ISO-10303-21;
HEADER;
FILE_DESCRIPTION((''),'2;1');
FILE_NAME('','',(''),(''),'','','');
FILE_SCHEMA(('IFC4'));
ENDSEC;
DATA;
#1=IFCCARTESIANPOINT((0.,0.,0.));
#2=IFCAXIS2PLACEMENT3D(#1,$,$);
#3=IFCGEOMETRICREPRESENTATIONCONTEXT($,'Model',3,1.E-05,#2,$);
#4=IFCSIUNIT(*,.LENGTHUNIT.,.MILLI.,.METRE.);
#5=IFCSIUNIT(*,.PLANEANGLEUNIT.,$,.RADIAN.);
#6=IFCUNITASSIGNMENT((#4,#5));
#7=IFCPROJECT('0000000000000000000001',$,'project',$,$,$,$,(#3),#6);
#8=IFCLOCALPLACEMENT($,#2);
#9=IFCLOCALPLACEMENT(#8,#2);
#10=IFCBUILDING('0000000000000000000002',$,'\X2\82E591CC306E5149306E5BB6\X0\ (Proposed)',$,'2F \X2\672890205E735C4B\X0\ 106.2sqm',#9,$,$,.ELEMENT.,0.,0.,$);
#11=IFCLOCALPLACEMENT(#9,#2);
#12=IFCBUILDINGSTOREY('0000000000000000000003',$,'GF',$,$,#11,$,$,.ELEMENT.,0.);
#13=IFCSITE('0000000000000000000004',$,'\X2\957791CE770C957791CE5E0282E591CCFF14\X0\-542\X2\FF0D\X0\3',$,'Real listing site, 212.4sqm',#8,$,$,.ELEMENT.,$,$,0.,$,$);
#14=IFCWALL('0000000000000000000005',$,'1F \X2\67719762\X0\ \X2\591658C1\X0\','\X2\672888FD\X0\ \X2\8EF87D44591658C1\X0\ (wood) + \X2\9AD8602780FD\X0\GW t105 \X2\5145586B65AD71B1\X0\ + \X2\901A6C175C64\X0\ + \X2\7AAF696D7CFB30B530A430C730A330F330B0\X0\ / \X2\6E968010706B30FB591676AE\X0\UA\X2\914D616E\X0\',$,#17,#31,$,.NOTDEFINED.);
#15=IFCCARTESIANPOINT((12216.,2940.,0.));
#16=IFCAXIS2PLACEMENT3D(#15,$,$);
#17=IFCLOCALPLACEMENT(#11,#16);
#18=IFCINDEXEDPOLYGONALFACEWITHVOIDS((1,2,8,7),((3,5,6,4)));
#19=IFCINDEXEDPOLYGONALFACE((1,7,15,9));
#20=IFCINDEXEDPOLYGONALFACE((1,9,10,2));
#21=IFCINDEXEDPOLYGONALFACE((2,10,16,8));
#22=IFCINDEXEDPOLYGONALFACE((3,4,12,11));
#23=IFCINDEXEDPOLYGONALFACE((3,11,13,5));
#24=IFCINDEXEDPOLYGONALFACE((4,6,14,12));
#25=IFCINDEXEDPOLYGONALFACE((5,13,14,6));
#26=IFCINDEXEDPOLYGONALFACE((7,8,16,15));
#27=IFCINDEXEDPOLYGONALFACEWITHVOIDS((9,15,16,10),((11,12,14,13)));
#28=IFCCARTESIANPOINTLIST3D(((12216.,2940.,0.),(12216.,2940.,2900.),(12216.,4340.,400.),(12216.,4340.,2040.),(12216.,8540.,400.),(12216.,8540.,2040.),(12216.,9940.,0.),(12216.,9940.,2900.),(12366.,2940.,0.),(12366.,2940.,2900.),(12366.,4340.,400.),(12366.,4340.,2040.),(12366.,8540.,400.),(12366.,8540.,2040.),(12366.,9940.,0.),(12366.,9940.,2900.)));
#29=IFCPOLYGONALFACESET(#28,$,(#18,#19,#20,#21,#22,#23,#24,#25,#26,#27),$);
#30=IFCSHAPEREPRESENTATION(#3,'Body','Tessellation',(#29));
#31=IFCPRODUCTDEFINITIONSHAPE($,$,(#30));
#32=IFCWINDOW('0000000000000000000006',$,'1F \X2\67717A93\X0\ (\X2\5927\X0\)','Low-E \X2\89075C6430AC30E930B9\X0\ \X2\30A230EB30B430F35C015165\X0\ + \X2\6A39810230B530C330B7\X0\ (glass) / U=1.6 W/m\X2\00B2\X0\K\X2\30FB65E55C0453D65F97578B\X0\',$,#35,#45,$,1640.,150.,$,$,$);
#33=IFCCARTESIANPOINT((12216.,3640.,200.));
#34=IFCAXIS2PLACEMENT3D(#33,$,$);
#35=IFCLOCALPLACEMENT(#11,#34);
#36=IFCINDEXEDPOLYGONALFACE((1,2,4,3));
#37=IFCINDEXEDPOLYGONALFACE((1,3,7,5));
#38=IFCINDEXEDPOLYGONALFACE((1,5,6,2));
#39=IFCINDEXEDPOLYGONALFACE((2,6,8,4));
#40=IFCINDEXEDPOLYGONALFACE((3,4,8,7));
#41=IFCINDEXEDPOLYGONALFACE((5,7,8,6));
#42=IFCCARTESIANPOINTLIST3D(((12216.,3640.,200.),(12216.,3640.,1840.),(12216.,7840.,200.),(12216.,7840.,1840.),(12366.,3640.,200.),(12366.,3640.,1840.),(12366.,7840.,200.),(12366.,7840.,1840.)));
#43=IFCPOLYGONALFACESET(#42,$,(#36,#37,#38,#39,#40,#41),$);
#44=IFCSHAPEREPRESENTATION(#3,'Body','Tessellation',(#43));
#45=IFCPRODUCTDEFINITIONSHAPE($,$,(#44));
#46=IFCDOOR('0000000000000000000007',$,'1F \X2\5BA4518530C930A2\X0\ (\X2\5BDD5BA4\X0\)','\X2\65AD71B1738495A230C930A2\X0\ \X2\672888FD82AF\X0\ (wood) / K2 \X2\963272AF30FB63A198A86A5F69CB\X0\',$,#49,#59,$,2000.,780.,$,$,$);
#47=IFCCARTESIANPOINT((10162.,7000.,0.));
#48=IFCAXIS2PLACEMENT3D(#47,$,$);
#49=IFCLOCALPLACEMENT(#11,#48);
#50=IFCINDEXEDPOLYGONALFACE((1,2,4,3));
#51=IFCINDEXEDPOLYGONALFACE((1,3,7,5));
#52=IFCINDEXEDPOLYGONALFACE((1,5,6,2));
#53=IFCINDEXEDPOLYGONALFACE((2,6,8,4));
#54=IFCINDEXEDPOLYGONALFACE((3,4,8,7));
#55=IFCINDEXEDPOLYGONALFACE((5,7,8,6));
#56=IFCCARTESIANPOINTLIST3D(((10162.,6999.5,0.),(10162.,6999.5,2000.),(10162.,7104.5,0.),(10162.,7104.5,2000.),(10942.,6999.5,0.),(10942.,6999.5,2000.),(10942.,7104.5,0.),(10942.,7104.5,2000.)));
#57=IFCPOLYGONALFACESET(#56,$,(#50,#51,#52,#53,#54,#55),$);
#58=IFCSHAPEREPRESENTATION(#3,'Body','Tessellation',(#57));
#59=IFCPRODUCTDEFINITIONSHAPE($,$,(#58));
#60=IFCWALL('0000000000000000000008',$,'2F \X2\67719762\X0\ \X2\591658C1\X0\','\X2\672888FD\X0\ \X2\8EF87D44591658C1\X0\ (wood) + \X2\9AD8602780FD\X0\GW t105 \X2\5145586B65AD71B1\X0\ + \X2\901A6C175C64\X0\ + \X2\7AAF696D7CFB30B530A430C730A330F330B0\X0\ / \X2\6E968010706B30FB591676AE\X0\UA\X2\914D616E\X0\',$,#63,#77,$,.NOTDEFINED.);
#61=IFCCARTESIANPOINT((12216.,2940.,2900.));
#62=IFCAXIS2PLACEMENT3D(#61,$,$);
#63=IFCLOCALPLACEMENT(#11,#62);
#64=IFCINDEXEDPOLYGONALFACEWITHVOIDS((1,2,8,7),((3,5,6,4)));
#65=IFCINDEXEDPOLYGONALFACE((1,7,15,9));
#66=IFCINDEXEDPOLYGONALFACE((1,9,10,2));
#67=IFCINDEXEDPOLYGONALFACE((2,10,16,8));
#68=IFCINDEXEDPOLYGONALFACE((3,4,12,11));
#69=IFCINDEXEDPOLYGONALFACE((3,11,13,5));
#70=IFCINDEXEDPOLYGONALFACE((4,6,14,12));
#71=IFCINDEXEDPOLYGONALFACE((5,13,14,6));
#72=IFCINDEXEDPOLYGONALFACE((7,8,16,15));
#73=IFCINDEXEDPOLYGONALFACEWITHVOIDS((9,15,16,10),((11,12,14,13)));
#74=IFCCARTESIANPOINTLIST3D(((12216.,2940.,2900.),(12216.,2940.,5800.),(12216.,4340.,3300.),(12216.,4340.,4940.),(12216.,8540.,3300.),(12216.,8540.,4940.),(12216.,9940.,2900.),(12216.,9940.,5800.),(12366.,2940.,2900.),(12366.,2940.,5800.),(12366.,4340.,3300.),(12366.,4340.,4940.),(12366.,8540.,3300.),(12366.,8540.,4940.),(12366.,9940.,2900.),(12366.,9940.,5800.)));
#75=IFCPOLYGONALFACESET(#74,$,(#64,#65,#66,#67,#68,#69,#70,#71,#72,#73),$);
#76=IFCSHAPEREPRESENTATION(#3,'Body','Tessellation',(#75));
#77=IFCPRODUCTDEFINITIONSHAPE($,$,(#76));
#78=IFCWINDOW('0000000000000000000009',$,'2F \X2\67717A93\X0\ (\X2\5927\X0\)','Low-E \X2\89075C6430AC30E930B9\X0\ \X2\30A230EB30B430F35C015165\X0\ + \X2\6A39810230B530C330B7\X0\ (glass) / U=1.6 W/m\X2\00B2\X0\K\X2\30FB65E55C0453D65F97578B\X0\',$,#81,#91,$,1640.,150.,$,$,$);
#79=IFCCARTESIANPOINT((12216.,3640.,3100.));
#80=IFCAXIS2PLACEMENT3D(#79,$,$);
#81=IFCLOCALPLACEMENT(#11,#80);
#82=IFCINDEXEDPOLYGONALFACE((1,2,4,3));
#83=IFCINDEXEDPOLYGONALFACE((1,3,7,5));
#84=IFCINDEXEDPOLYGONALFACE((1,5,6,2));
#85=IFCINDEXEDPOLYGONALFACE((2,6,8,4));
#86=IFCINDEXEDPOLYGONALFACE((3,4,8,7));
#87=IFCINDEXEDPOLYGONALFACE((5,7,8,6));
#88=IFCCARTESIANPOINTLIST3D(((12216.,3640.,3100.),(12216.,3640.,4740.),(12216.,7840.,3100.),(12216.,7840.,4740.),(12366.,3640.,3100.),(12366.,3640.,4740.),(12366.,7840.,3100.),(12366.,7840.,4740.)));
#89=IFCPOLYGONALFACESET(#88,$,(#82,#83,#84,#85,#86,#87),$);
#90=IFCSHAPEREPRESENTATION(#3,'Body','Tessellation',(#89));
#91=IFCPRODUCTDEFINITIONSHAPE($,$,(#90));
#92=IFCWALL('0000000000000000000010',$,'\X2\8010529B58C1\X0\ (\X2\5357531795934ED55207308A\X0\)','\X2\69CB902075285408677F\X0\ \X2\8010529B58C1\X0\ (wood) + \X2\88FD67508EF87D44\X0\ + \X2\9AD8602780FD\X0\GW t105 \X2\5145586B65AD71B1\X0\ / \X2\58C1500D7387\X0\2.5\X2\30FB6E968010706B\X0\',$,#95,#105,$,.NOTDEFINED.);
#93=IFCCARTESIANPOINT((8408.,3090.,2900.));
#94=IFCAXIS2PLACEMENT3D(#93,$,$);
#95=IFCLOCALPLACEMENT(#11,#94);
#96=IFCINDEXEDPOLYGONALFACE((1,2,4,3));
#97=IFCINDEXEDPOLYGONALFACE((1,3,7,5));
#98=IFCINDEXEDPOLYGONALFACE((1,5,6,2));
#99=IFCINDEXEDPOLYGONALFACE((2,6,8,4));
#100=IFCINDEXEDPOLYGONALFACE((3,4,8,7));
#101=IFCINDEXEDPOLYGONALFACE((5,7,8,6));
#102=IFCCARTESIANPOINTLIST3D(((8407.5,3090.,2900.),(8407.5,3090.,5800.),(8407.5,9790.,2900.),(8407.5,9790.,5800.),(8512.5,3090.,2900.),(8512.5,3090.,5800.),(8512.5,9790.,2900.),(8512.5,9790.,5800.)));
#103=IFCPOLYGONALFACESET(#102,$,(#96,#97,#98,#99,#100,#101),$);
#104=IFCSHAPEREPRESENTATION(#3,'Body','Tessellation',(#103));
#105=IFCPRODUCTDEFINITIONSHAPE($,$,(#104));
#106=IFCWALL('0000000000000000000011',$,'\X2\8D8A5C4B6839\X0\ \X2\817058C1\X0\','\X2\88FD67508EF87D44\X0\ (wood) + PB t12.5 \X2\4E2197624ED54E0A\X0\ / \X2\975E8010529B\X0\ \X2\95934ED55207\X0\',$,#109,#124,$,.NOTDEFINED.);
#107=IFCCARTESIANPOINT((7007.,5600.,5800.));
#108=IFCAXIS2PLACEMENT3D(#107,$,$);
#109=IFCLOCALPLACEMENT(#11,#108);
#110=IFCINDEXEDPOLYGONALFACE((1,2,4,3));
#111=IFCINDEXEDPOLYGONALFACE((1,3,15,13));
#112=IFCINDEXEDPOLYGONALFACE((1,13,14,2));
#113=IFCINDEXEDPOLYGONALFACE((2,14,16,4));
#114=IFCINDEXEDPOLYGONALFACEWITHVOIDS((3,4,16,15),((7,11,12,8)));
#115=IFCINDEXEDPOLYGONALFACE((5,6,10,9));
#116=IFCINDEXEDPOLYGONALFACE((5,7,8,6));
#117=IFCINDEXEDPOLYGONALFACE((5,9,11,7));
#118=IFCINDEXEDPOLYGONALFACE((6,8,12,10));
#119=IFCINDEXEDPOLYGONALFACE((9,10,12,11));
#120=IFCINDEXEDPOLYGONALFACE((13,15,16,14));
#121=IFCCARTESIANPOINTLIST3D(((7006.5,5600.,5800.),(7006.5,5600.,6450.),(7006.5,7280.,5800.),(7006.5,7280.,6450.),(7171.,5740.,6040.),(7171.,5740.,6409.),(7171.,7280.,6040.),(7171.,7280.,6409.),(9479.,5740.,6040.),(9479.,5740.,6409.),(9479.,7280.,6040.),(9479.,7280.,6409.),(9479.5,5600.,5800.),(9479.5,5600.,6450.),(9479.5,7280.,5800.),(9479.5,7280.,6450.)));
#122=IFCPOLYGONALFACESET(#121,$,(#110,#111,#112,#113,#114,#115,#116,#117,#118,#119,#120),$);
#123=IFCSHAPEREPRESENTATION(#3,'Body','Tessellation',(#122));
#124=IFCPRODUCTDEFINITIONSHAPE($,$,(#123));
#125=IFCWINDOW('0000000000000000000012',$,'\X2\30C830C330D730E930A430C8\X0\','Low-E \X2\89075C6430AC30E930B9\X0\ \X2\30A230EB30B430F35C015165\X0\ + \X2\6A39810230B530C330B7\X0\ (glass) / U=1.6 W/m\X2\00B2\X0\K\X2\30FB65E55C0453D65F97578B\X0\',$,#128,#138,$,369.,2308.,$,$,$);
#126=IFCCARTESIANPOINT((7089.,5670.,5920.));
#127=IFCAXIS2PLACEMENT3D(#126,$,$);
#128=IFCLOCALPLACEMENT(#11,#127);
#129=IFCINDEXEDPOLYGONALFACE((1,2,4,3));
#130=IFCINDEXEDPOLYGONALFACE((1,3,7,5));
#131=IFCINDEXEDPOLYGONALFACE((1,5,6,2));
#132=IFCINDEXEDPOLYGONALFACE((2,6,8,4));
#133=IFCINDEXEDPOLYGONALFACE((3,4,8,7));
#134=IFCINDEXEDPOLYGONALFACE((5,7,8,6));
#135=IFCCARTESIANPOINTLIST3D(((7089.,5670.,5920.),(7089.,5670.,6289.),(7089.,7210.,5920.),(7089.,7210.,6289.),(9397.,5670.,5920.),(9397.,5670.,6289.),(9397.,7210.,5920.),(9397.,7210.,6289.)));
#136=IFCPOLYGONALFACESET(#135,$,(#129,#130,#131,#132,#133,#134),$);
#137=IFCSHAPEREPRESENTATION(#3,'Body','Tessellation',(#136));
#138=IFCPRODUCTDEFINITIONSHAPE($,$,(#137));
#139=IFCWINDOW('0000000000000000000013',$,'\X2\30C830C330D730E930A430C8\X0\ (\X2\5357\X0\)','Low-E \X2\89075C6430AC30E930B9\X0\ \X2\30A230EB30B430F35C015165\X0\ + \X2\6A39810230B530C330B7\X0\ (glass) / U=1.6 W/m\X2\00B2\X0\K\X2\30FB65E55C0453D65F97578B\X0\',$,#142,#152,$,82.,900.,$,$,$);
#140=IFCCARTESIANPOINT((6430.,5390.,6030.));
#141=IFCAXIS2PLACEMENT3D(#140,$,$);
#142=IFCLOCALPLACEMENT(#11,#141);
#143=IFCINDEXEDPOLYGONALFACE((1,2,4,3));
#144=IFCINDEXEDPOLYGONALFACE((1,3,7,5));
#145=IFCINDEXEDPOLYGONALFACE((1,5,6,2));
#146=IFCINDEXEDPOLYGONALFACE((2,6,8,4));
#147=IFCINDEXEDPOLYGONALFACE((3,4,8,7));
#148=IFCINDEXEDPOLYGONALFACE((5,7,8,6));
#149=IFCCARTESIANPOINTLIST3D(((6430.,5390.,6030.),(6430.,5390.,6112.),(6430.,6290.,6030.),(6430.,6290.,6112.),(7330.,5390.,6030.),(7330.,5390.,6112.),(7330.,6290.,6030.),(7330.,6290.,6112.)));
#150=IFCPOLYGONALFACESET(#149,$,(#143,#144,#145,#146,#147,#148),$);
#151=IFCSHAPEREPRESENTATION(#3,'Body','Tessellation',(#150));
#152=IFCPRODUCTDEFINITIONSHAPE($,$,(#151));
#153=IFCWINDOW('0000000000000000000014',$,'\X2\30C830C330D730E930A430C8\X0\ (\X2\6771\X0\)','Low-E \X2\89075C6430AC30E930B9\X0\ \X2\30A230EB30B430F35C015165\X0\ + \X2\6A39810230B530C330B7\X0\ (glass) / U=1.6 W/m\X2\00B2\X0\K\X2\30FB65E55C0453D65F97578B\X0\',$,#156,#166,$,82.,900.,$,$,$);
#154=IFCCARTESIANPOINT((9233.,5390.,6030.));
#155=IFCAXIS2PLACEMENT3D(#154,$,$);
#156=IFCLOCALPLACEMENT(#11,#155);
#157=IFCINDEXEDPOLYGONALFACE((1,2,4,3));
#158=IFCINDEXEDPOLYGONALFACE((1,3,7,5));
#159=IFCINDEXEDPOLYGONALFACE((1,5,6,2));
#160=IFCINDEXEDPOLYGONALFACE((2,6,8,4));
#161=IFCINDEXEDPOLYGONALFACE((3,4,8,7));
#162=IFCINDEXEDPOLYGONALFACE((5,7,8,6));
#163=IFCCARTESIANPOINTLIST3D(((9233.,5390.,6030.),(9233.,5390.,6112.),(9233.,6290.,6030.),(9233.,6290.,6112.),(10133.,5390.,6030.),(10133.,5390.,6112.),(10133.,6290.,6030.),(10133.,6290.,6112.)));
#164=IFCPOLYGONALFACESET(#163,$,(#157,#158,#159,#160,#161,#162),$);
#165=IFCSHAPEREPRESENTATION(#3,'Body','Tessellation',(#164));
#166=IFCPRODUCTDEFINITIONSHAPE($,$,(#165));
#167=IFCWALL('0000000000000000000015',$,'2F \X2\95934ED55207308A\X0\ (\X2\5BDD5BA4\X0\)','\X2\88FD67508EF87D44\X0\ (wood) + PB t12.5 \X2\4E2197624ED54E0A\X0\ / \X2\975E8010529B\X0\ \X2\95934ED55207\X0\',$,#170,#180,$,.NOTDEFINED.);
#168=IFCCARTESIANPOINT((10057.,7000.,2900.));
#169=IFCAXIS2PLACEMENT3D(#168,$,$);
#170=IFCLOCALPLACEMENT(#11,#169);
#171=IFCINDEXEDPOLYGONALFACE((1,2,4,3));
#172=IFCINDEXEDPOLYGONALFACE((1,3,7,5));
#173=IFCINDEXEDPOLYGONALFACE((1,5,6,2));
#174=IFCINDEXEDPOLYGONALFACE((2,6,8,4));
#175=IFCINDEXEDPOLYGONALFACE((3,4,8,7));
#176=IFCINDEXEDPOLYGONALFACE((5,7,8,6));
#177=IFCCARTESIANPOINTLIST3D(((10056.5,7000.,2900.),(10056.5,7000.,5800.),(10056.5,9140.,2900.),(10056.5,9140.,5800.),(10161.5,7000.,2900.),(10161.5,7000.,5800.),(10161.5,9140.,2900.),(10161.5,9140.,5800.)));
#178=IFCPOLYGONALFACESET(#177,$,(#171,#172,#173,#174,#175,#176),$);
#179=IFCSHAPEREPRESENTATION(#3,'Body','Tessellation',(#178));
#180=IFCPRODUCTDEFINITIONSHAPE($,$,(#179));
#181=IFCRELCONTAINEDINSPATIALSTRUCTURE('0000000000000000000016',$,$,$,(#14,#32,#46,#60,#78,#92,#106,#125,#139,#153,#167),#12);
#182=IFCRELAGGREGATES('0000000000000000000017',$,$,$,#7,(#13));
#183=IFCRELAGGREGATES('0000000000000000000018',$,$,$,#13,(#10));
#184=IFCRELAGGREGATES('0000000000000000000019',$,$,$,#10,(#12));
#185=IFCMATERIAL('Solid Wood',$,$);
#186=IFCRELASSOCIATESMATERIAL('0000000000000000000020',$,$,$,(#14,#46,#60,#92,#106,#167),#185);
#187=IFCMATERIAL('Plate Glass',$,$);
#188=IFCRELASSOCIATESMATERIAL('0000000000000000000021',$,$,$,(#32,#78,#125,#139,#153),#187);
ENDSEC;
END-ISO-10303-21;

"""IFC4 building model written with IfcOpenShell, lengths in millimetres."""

from ifc_helpers import new_model, si_unit, frame, frame_2d, origin, place, context, project, spatial, rectangle, extrude, material, element, fill, save


model = new_model("IFC4")

# Units and contexts
model_context = context("Model", 3, precision=1e-05, world=origin())
ifc_project = project(units=[si_unit("LENGTHUNIT", "METRE", prefix="MILLI"), si_unit("PLANEANGLEUNIT", "RADIAN")], contexts=[model_context])

# Site, building, storey
site_placement = place(None, origin())
site = spatial("IfcSite", under=ifc_project, at=site_placement, Name="長野県長野市若里４-542－3", ObjectType="Real listing site, 212.4sqm", CompositionType="ELEMENT", RefElevation=0.0)
building_placement = place(site_placement, origin())
building = spatial("IfcBuilding", under=site, at=building_placement, Name="若里の光の家 (Proposed)", ObjectType="2F 木造平屋 106.2sqm", CompositionType="ELEMENT", ElevationOfRefHeight=0.0, ElevationOfTerrain=0.0)
storey_placement = place(building_placement, origin())
storey = spatial("IfcBuildingStorey", under=building, at=storey_placement, Name="GF", CompositionType="ELEMENT", Elevation=0.0)

# Wall, opening, window
ifc_material_1 = material(Name="Solid Wood")
wall_1_placement = place(storey_placement, frame((12216.0, 2940.0, 0.0)))
wall_1 = element("IfcWall", 1, at=wall_1_placement, inside=storey, material=ifc_material_1, Name="1F 東面 外壁", Description="木製 軸組外壁 (wood) + 高性能GW t105 充填断熱 + 通気層 + 窯業系サイディング / 準耐火・外皮UA配慮", PredefinedType="NOTDEFINED", context=model_context, shape_type="SweptSolid", body=[
    extrude(rectangle(XDim=150.0, YDim=7000.0, at=frame_2d((75.0, 3500.0))), frame((12216.0, 2940.0, 0.0)), (0.0, 0.0, 1.0), 2900.0),
])
opening_1_placement = place(storey_placement, frame((12216.0, 3640.0, 200.0)))
opening_1 = element("IfcOpeningElement", 2, at=opening_1_placement, cuts=wall_1, PredefinedType="NOTDEFINED", context=model_context, shape_type="SweptSolid", body=[
    extrude(rectangle(XDim=150.0, YDim=4200.0, at=frame_2d((75.0, 2100.0))), frame((12216.0, 3640.0, 200.0)), (0.0, 0.0, 1.0), 1640.0),
])
ifc_material_2 = material(Name="Plate Glass")
window_1_placement = place(storey_placement, frame((12216.0, 3640.0, 200.0)))
window_1 = element("IfcWindow", 3, at=window_1_placement, inside=storey, material=ifc_material_2, Name="1F 東窓 (大)", Description="Low-E 複層ガラス アルゴン封入 + 樹脂サッシ (glass) / U=1.6 W/m²K・日射取得型", OverallHeight=1640.0, OverallWidth=150.0, context=model_context, shape_type="SweptSolid", body=[
    extrude(rectangle(XDim=150.0, YDim=4200.0, at=frame_2d((75.0, 2100.0))), frame((12216.0, 3640.0, 200.0)), (0.0, 0.0, 1.0), 1640.0),
])
fill(opening_1, window_1)

# Door
door_1_placement = place(storey_placement, frame((10162.0, 7000.0, 0.0)))
element("IfcDoor", 4, at=door_1_placement, inside=storey, material=ifc_material_1, Name="1F 室内ドア (寝室)", Description="断熱玄関ドア 木製芯 (wood) / K2 防犯・採風機構", OverallHeight=2000.0, OverallWidth=780.0, context=model_context, shape_type="SweptSolid", body=[
    extrude(rectangle(XDim=780.0, YDim=105.0, at=frame_2d((390.0, 52.0))), frame((10162.0, 7000.0, 0.0)), (0.0, 0.0, 1.0), 2000.0),
])

# Wall, opening, window
wall_2_placement = place(storey_placement, frame((12216.0, 2940.0, 2900.0)))
wall_2 = element("IfcWall", 5, at=wall_2_placement, inside=storey, material=ifc_material_1, Name="2F 東面 外壁", Description="木製 軸組外壁 (wood) + 高性能GW t105 充填断熱 + 通気層 + 窯業系サイディング / 準耐火・外皮UA配慮", PredefinedType="NOTDEFINED", context=model_context, shape_type="SweptSolid", body=[
    extrude(rectangle(XDim=150.0, YDim=7000.0, at=frame_2d((75.0, 3500.0))), frame((12216.0, 2940.0, 2900.0)), (0.0, 0.0, 1.0), 2900.0),
])
opening_2_placement = place(storey_placement, frame((12216.0, 3640.0, 3100.0)))
opening_2 = element("IfcOpeningElement", 6, at=opening_2_placement, cuts=wall_2, PredefinedType="NOTDEFINED", context=model_context, shape_type="SweptSolid", body=[
    extrude(rectangle(XDim=150.0, YDim=4200.0, at=frame_2d((75.0, 2100.0))), frame((12216.0, 3640.0, 3100.0)), (0.0, 0.0, 1.0), 1640.0),
])
window_2_placement = place(storey_placement, frame((12216.0, 3640.0, 3100.0)))
window_2 = element("IfcWindow", 7, at=window_2_placement, inside=storey, material=ifc_material_2, Name="2F 東窓 (大)", Description="Low-E 複層ガラス アルゴン封入 + 樹脂サッシ (glass) / U=1.6 W/m²K・日射取得型", OverallHeight=1640.0, OverallWidth=150.0, context=model_context, shape_type="SweptSolid", body=[
    extrude(rectangle(XDim=150.0, YDim=4200.0, at=frame_2d((75.0, 2100.0))), frame((12216.0, 3640.0, 3100.0)), (0.0, 0.0, 1.0), 1640.0),
])
fill(opening_2, window_2)

# Wall
wall_3_placement = place(storey_placement, frame((8408.0, 3090.0, 2900.0)))
element("IfcWall", 8, at=wall_3_placement, inside=storey, material=ifc_material_1, Name="耐力壁 (南北間仕切り)", Description="構造用合板 耐力壁 (wood) + 製材軸組 + 高性能GW t105 充填断熱 / 壁倍率2.5・準耐火", PredefinedType="NOTDEFINED", context=model_context, shape_type="SweptSolid", body=[
    extrude(rectangle(XDim=105.0, YDim=6700.0, at=frame_2d((52.0, 3350.0))), frame((8408.0, 3090.0, 2900.0)), (0.0, 0.0, 1.0), 2900.0),
])

# Wall, openings, windows
wall_4_placement = place(storey_placement, frame((7007.0, 5600.0, 5800.0)))
wall_4 = element("IfcWall", 9, at=wall_4_placement, inside=storey, material=ifc_material_1, Name="越屋根 腰壁", Description="製材軸組 (wood) + PB t12.5 両面仕上 / 非耐力 間仕切", PredefinedType="NOTDEFINED", context=model_context, shape_type="SweptSolid", body=[
    extrude(rectangle(XDim=2473.0, YDim=1680.0, at=frame_2d((1236.0, 840.0))), frame((7007.0, 5600.0, 5800.0)), (0.0, 0.0, 1.0), 650.0),
])
opening_3_placement = place(storey_placement, frame((7089.0, 5670.0, 5920.0)))
opening_3 = element("IfcOpeningElement", 10, at=opening_3_placement, cuts=wall_4, PredefinedType="NOTDEFINED", context=model_context, shape_type="SweptSolid", body=[
    extrude(rectangle(XDim=2308.0, YDim=1540.0, at=frame_2d((1154.0, 770.0))), frame((7089.0, 5670.0, 5920.0)), (0.0, 0.0, 1.0), 369.0),
])
opening_4_placement = place(storey_placement, frame((6430.0, 5390.0, 6030.0)))
opening_4 = element("IfcOpeningElement", 11, at=opening_4_placement, cuts=wall_4, PredefinedType="NOTDEFINED", context=model_context, shape_type="SweptSolid", body=[
    extrude(rectangle(XDim=900.0, YDim=900.0, at=frame_2d((450.0, 450.0))), frame((6430.0, 5390.0, 6030.0)), (0.0, 0.0, 1.0), 82.0),
])
opening_5_placement = place(storey_placement, frame((9233.0, 5390.0, 6030.0)))
opening_5 = element("IfcOpeningElement", 12, at=opening_5_placement, cuts=wall_4, PredefinedType="NOTDEFINED", context=model_context, shape_type="SweptSolid", body=[
    extrude(rectangle(XDim=900.0, YDim=900.0, at=frame_2d((450.0, 450.0))), frame((9233.0, 5390.0, 6030.0)), (0.0, 0.0, 1.0), 82.0),
])
window_3_placement = place(storey_placement, frame((7089.0, 5670.0, 5920.0)))
window_3 = element("IfcWindow", 13, at=window_3_placement, inside=storey, material=ifc_material_2, Name="トップライト", Description="Low-E 複層ガラス アルゴン封入 + 樹脂サッシ (glass) / U=1.6 W/m²K・日射取得型", OverallHeight=369.0, OverallWidth=2308.0, context=model_context, shape_type="SweptSolid", body=[
    extrude(rectangle(XDim=2308.0, YDim=1540.0, at=frame_2d((1154.0, 770.0))), frame((7089.0, 5670.0, 5920.0)), (0.0, 0.0, 1.0), 369.0),
])
fill(opening_3, window_3)
window_4_placement = place(storey_placement, frame((6430.0, 5390.0, 6030.0)))
window_4 = element("IfcWindow", 14, at=window_4_placement, inside=storey, material=ifc_material_2, Name="トップライト (南)", Description="Low-E 複層ガラス アルゴン封入 + 樹脂サッシ (glass) / U=1.6 W/m²K・日射取得型", OverallHeight=82.0, OverallWidth=900.0, context=model_context, shape_type="SweptSolid", body=[
    extrude(rectangle(XDim=900.0, YDim=900.0, at=frame_2d((450.0, 450.0))), frame((6430.0, 5390.0, 6030.0)), (0.0, 0.0, 1.0), 82.0),
])
fill(opening_4, window_4)
window_5_placement = place(storey_placement, frame((9233.0, 5390.0, 6030.0)))
window_5 = element("IfcWindow", 15, at=window_5_placement, inside=storey, material=ifc_material_2, Name="トップライト (東)", Description="Low-E 複層ガラス アルゴン封入 + 樹脂サッシ (glass) / U=1.6 W/m²K・日射取得型", OverallHeight=82.0, OverallWidth=900.0, context=model_context, shape_type="SweptSolid", body=[
    extrude(rectangle(XDim=900.0, YDim=900.0, at=frame_2d((450.0, 450.0))), frame((9233.0, 5390.0, 6030.0)), (0.0, 0.0, 1.0), 82.0),
])
fill(opening_5, window_5)

# Wall
wall_5_placement = place(storey_placement, frame((10057.0, 7000.0, 2900.0)))
element("IfcWall", 16, at=wall_5_placement, inside=storey, material=ifc_material_1, Name="2F 間仕切り (寝室)", Description="製材軸組 (wood) + PB t12.5 両面仕上 / 非耐力 間仕切", PredefinedType="NOTDEFINED", context=model_context, shape_type="SweptSolid", body=[
    extrude(rectangle(XDim=105.0, YDim=2140.0, at=frame_2d((52.0, 1070.0))), frame((10057.0, 7000.0, 2900.0)), (0.0, 0.0, 1.0), 2900.0),
])

save(model, "model.ifc")
